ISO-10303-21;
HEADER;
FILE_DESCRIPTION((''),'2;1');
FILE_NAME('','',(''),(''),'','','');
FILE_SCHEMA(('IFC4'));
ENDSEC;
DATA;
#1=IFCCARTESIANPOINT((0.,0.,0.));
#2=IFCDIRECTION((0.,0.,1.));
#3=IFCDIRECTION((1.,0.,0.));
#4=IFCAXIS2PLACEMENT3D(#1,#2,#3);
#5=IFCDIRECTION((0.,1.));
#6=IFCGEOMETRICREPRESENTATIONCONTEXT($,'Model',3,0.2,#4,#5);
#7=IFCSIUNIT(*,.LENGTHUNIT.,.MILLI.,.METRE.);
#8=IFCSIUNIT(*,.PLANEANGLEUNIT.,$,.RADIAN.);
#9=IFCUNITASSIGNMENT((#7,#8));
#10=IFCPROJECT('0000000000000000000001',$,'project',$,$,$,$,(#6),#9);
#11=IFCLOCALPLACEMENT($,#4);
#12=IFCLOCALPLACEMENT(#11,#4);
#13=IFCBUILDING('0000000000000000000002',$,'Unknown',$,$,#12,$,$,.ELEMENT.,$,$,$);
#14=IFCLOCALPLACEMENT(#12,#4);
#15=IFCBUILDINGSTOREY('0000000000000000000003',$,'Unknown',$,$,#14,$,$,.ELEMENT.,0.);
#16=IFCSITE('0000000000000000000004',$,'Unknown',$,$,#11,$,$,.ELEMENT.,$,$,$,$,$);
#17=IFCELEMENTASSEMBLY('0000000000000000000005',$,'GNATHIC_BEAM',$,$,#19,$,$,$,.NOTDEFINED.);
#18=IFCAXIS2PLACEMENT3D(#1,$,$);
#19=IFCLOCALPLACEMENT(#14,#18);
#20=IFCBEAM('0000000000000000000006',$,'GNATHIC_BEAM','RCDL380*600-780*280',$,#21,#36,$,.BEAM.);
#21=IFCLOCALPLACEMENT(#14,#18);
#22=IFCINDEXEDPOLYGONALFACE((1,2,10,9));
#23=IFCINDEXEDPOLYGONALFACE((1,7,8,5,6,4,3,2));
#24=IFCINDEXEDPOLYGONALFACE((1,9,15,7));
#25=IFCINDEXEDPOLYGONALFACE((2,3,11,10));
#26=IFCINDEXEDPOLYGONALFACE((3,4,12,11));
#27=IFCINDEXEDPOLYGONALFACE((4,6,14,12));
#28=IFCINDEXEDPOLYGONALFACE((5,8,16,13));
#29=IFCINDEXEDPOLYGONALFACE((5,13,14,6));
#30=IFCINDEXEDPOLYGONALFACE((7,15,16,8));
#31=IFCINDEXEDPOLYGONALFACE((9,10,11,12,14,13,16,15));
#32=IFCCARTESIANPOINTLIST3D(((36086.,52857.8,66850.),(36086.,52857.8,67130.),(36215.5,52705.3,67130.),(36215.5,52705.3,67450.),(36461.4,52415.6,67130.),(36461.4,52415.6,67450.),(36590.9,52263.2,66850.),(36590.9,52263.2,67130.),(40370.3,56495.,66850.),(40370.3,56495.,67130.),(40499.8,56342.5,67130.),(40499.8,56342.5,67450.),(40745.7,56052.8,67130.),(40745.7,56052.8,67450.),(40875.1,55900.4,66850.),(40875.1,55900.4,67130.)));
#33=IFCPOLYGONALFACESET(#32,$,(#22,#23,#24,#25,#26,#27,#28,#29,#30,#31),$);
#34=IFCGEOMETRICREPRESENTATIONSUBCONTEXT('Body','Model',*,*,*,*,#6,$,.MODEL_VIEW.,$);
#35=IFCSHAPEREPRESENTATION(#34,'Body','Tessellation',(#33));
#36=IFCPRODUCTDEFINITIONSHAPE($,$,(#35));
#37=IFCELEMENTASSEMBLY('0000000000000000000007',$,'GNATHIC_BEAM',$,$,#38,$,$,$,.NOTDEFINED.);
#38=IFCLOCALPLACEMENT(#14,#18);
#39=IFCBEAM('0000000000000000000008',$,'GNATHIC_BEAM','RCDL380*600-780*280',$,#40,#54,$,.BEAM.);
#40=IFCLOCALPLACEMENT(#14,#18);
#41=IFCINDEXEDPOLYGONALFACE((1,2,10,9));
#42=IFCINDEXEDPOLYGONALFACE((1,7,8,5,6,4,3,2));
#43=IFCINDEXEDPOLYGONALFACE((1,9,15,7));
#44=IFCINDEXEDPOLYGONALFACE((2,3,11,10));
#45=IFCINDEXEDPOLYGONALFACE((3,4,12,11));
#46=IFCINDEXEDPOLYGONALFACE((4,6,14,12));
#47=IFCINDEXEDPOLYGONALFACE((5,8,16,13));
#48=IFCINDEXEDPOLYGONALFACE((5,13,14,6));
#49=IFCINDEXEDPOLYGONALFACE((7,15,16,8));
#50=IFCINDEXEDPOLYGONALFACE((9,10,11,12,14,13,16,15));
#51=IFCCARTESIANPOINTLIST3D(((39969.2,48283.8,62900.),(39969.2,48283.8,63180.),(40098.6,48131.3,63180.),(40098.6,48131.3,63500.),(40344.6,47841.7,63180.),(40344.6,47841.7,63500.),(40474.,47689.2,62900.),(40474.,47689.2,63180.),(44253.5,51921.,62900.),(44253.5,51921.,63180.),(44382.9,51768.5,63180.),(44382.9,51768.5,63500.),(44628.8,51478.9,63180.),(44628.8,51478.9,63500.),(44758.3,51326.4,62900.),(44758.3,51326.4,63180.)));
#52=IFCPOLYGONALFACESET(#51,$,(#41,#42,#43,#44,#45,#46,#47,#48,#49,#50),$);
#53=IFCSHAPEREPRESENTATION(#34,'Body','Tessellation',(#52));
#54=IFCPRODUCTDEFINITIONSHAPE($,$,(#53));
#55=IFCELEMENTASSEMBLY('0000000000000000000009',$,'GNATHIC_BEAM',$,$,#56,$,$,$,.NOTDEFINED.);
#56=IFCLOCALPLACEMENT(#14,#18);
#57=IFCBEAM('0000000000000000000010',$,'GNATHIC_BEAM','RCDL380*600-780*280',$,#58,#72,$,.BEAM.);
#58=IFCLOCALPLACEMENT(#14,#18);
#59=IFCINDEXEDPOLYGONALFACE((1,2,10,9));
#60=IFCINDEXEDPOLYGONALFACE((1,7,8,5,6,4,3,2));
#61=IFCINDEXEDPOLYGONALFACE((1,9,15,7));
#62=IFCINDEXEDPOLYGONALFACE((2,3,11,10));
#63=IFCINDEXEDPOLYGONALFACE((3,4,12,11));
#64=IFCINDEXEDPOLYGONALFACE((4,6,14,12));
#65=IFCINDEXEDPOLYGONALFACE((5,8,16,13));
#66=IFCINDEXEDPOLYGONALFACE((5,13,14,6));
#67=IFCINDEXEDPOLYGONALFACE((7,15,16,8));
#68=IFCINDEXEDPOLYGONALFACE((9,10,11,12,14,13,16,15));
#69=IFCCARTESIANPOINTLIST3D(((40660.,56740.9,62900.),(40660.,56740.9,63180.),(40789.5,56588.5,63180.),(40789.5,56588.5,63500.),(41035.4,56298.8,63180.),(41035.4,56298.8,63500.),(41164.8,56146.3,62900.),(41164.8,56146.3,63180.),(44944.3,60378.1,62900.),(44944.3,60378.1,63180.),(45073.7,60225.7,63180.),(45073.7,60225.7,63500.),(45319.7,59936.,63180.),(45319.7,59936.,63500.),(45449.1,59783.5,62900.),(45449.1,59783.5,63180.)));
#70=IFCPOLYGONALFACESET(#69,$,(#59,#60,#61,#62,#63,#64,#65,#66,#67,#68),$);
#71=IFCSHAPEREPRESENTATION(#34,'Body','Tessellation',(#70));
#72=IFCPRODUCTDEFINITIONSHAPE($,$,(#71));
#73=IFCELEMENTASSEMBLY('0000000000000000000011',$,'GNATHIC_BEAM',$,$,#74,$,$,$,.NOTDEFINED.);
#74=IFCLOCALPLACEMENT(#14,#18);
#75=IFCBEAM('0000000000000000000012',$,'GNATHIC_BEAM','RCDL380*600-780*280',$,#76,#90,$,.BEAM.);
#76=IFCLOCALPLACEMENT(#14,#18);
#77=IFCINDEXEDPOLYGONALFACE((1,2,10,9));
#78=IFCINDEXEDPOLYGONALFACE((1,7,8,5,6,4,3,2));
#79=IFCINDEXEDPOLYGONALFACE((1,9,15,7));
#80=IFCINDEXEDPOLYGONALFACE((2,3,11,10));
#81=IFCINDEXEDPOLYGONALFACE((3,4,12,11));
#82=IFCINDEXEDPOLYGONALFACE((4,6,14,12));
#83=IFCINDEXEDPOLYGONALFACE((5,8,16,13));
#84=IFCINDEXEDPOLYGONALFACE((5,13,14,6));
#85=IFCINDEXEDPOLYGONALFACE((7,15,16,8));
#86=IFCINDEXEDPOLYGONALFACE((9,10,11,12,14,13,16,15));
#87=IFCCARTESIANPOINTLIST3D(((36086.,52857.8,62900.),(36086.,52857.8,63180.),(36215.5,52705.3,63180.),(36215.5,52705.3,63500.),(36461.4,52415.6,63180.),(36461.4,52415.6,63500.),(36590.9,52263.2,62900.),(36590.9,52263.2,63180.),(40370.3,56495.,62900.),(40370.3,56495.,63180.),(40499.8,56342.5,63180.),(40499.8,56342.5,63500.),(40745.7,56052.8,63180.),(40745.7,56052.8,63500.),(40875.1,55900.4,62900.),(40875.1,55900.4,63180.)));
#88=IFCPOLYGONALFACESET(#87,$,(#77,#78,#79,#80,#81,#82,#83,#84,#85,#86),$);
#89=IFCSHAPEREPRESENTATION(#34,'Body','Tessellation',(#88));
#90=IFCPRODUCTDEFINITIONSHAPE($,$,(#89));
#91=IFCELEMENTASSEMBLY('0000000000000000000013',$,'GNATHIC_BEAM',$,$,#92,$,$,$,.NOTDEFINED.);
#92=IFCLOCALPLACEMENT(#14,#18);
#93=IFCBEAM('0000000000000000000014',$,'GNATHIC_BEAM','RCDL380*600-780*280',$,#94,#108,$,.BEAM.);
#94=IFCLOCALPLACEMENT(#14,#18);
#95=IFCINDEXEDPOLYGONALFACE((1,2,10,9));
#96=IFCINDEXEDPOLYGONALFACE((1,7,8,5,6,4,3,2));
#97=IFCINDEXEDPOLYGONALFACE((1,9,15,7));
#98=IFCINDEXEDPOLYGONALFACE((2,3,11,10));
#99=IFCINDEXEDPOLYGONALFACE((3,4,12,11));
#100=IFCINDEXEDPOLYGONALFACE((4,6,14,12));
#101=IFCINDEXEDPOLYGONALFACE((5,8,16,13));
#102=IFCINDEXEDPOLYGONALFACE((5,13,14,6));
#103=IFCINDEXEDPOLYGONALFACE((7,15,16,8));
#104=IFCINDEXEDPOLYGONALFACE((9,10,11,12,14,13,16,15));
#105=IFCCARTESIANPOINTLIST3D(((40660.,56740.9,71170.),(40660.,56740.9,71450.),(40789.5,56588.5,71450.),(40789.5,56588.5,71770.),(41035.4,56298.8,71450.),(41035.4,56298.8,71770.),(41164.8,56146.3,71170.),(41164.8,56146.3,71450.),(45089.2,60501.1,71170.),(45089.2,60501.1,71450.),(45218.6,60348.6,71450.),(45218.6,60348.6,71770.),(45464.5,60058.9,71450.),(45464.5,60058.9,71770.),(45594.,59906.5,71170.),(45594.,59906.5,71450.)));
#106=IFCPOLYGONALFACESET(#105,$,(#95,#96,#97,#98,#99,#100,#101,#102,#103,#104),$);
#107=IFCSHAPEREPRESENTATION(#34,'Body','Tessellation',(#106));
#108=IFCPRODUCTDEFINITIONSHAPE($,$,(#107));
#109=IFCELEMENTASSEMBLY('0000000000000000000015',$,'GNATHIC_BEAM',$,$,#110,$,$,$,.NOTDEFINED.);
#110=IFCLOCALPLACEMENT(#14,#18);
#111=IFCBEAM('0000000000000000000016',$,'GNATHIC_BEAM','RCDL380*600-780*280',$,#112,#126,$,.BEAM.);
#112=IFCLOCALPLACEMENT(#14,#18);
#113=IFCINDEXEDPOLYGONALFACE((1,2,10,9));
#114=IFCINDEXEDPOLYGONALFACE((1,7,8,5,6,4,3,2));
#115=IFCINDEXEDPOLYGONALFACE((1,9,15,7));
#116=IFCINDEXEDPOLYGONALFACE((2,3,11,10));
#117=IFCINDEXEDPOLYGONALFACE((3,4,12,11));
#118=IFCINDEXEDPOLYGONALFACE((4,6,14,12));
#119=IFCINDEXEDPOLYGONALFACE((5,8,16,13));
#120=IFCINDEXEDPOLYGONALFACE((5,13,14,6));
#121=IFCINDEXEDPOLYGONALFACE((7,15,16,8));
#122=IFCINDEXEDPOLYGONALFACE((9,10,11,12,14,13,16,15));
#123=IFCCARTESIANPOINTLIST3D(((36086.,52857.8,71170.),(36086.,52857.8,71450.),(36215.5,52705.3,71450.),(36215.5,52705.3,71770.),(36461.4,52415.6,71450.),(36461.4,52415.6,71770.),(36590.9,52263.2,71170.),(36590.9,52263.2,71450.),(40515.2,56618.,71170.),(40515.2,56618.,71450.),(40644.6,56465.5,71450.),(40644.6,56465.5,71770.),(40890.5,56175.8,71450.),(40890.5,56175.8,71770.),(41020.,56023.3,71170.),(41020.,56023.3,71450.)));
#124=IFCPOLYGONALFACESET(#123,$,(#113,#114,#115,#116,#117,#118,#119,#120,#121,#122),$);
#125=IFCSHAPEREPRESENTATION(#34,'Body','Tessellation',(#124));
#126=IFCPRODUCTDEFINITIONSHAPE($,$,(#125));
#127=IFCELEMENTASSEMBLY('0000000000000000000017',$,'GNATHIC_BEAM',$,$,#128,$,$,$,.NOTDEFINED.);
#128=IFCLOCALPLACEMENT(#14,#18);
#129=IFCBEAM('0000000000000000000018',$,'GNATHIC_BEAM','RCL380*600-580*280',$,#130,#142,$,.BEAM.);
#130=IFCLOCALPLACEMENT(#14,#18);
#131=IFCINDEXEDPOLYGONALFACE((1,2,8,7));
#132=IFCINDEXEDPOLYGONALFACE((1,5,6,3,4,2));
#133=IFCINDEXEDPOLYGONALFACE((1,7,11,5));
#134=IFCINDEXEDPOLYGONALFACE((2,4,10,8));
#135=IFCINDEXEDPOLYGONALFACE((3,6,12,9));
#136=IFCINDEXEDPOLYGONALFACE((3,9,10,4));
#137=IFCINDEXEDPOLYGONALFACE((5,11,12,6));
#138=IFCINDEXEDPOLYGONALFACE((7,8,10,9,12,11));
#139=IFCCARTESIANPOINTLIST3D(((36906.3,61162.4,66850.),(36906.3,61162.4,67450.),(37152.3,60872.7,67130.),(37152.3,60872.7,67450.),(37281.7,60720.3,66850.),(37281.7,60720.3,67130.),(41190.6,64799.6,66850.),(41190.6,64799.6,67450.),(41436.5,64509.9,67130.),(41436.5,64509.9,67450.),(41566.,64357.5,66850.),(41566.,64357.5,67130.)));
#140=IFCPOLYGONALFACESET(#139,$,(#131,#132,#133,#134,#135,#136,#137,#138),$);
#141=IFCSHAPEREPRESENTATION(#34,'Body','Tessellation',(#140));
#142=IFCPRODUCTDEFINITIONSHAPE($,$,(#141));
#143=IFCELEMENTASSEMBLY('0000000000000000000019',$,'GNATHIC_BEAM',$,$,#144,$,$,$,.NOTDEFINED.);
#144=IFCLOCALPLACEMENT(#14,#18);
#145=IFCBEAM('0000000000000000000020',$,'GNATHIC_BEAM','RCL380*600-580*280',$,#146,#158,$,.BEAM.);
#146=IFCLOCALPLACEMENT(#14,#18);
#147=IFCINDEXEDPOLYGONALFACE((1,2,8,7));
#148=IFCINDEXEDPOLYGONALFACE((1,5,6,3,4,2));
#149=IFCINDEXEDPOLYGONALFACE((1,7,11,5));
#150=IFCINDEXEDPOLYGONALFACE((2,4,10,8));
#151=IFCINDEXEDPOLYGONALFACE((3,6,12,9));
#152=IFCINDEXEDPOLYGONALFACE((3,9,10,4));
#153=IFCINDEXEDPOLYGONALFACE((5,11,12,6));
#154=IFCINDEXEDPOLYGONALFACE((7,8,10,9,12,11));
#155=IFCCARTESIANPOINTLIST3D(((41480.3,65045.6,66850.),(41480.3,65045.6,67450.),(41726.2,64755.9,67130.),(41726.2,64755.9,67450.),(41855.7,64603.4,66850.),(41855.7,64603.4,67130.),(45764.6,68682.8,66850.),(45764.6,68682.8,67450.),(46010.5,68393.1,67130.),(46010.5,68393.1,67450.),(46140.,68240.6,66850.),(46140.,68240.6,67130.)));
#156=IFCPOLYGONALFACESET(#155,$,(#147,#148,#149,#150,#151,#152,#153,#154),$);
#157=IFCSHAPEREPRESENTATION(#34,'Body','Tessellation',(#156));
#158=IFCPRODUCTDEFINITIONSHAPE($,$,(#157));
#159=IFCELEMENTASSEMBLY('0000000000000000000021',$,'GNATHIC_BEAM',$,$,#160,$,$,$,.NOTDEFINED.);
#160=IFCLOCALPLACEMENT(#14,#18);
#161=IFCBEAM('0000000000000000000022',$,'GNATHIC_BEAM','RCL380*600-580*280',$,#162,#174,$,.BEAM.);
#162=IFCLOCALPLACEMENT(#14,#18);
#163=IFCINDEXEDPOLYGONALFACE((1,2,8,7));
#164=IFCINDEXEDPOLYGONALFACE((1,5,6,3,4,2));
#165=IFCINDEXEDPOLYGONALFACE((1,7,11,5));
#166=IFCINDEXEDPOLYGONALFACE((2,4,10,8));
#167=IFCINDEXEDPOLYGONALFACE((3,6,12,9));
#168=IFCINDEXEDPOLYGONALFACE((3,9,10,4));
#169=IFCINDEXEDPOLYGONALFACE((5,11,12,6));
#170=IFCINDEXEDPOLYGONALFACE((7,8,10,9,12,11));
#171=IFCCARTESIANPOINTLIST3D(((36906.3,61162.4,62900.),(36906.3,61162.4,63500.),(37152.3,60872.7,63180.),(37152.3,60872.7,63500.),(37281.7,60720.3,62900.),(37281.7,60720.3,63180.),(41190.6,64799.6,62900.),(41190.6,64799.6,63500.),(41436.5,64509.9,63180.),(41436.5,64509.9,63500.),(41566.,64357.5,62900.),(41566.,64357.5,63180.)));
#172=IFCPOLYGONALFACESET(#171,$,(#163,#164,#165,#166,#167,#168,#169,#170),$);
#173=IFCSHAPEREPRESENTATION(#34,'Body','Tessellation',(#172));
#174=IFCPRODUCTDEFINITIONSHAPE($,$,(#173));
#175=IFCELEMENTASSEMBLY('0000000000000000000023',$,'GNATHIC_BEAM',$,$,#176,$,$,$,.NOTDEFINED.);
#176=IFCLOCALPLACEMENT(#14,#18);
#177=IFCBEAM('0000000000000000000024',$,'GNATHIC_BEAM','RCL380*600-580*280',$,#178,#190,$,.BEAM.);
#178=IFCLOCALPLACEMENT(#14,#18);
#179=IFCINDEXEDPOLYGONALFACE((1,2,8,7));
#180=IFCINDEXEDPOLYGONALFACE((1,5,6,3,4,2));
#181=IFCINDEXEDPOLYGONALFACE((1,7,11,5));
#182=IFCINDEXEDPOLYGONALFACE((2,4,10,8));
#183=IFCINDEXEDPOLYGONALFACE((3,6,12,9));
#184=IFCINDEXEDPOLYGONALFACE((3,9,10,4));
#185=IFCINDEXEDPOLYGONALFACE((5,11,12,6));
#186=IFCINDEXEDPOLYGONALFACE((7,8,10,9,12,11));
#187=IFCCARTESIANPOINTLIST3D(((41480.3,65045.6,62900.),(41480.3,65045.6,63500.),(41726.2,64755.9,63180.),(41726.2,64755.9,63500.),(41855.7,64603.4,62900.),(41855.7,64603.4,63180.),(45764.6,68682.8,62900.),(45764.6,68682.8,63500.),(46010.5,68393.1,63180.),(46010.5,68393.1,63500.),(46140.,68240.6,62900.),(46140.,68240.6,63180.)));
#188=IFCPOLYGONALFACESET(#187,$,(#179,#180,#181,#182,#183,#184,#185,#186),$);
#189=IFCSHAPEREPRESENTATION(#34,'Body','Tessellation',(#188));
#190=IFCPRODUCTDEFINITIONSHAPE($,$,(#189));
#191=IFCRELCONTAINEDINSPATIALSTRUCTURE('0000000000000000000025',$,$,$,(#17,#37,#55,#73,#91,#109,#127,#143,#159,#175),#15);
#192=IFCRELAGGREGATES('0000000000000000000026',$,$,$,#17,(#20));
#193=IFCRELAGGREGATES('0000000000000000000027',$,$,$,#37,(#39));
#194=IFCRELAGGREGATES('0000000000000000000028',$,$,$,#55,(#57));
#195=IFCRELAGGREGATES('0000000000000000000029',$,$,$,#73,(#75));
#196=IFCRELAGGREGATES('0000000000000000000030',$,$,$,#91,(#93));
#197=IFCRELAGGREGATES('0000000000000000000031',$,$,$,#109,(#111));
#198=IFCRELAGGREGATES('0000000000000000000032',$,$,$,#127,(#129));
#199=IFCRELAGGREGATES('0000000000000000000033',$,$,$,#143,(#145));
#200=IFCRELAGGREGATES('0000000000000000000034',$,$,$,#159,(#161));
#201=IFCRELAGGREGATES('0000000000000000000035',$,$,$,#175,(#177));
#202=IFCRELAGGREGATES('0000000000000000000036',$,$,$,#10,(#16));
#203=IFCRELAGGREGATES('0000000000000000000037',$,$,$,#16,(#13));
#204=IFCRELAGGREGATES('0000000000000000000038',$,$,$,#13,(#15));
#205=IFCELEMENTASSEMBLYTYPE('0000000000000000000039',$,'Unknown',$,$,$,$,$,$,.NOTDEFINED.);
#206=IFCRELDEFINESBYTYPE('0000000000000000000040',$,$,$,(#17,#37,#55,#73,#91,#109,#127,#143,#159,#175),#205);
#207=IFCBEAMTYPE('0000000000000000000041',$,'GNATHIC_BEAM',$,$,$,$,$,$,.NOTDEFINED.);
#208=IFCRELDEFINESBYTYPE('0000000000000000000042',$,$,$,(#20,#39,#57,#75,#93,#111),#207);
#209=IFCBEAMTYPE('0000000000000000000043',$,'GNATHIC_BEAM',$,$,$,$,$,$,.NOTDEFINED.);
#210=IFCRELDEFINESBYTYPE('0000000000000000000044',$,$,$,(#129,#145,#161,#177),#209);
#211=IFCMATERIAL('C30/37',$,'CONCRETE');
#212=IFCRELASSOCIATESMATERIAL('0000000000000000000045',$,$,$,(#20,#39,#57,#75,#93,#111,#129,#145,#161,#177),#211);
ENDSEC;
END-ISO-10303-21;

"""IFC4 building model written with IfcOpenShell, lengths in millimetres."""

from ifc_helpers import new_model, si_unit, direction, frame, origin_with_axes, place, context, subcontext, project, spatial, polyline, outline, extrude, material, material_profile, profile_set, profile_usage, type_object, element, aggregate, save


model = new_model("IFC4")

# Units and contexts
model_context = context("Model", 3, precision=0.2, world=origin_with_axes(), true_north=direction((0.0, 1.0)))
body_context = subcontext(model_context, "Body", "Model", "MODEL_VIEW")
ifc_project = project(units=[si_unit("LENGTHUNIT", "METRE", prefix="MILLI"), si_unit("PLANEANGLEUNIT", "RADIAN")], contexts=[model_context])

# Site, building, storey
site_placement = place(None, origin_with_axes())
site = spatial("IfcSite", under=ifc_project, at=site_placement, Name="Unknown", CompositionType="ELEMENT")
building_placement = place(site_placement, origin_with_axes())
building = spatial("IfcBuilding", under=site, at=building_placement, Name="Unknown", CompositionType="ELEMENT")
storey_placement = place(building_placement, origin_with_axes())
storey = spatial("IfcBuildingStorey", under=building, at=storey_placement, Name="Unknown", CompositionType="ELEMENT", Elevation=0.0)

# Shared definitions
element_assembly_type = type_object("IfcElementAssemblyType", Name="Unknown", PredefinedType="NOTDEFINED")

# Element assemblies, beams
ifc_material_1 = material(Name="C30/37", Category="CONCRETE")
ifc_material_profile_1 = material_profile(ifc_material_1, outline(polyline([(-390.0, -300.0), (390.0, -300.0), (390.0, -20.0), (190.0, -20.0), (190.0, 300.0), (-190.0, 300.0), (-190.0, -20.0), (-390.0, -20.0), (-390.0, -300.0)])), Name="RCDL380*600-780*280")
ifc_profile_set_1 = profile_set([ifc_material_profile_1])
ifc_profile_usage_1 = profile_usage(ifc_profile_set_1, cardinal=2)
beam_type_1 = type_object("IfcBeamType", Name="GNATHIC_BEAM")
assembly_1_placement = place(storey_placement, frame((36338.5, 52560.5, 67150.0), z_axis=(0.64719, -0.762329, 0.0), x_axis=(0.762329, 0.64719, 0.0)))
assembly_1 = element("IfcElementAssembly", 1, at=assembly_1_placement, inside=storey, type_object=element_assembly_type, Name="GNATHIC_BEAM", PredefinedType="NOTDEFINED")
beam_1_placement = place(assembly_1_placement, origin_with_axes())
beam_1 = element("IfcBeam", 2, at=beam_1_placement, type_object=beam_type_1, material=ifc_profile_usage_1, Name="GNATHIC_BEAM", Description="RCDL380*600-780*280", PredefinedType="BEAM", context=body_context, shape_type="SolidModel", body=[
    extrude(outline(polyline([(-390.0, -300.0), (390.0, -300.0), (390.0, -20.0), (190.0, -20.0), (190.0, 300.0), (-190.0, 300.0), (-190.0, -20.0), (-390.0, -20.0), (-390.0, -300.0)])), frame((0.0, 0.0, 0.0), z_axis=(-1.0, 0.0, 0.0), x_axis=(0.0, 0.0, 1.0)), (0.0, 0.0, -1.0), 5620.0),
])
aggregate(assembly_1, [beam_1])
assembly_2_placement = place(storey_placement, frame((40221.6, 47986.5, 63200.0), z_axis=(0.64719, -0.762329, 0.0), x_axis=(0.762329, 0.64719, 0.0)))
assembly_2 = element("IfcElementAssembly", 3, at=assembly_2_placement, inside=storey, type_object=element_assembly_type, Name="GNATHIC_BEAM", PredefinedType="NOTDEFINED")
beam_2_placement = place(assembly_2_placement, origin_with_axes())
beam_2 = element("IfcBeam", 4, at=beam_2_placement, type_object=beam_type_1, material=ifc_profile_usage_1, Name="GNATHIC_BEAM", Description="RCDL380*600-780*280", PredefinedType="BEAM", context=body_context, shape_type="SolidModel", body=[
    extrude(outline(polyline([(-390.0, -300.0), (390.0, -300.0), (390.0, -20.0), (190.0, -20.0), (190.0, 300.0), (-190.0, 300.0), (-190.0, -20.0), (-390.0, -20.0), (-390.0, -300.0)])), frame((0.0, 0.0, 0.0), z_axis=(-1.0, 0.0, 0.0), x_axis=(0.0, 0.0, 1.0)), (0.0, 0.0, -1.0), 5620.0),
])
aggregate(assembly_2, [beam_2])
assembly_3_placement = place(storey_placement, frame((40912.4, 56443.6, 63200.0), z_axis=(0.64719, -0.762329, 0.0), x_axis=(0.762329, 0.64719, 0.0)))
assembly_3 = element("IfcElementAssembly", 5, at=assembly_3_placement, inside=storey, type_object=element_assembly_type, Name="GNATHIC_BEAM", PredefinedType="NOTDEFINED")
beam_3_placement = place(assembly_3_placement, origin_with_axes())
beam_3 = element("IfcBeam", 6, at=beam_3_placement, type_object=beam_type_1, material=ifc_profile_usage_1, Name="GNATHIC_BEAM", Description="RCDL380*600-780*280", PredefinedType="BEAM", context=body_context, shape_type="SolidModel", body=[
    extrude(outline(polyline([(-390.0, -300.0), (390.0, -300.0), (390.0, -20.0), (190.0, -20.0), (190.0, 300.0), (-190.0, 300.0), (-190.0, -20.0), (-390.0, -20.0), (-390.0, -300.0)])), frame((0.0, 0.0, 0.0), z_axis=(-1.0, 0.0, 0.0), x_axis=(0.0, 0.0, 1.0)), (0.0, 0.0, -1.0), 5620.0),
])
aggregate(assembly_3, [beam_3])
assembly_4_placement = place(storey_placement, frame((36338.5, 52560.5, 63200.0), z_axis=(0.64719, -0.762329, 0.0), x_axis=(0.762329, 0.64719, 0.0)))
assembly_4 = element("IfcElementAssembly", 7, at=assembly_4_placement, inside=storey, type_object=element_assembly_type, Name="GNATHIC_BEAM", PredefinedType="NOTDEFINED")
beam_4_placement = place(assembly_4_placement, origin_with_axes())
beam_4 = element("IfcBeam", 8, at=beam_4_placement, type_object=beam_type_1, material=ifc_profile_usage_1, Name="GNATHIC_BEAM", Description="RCDL380*600-780*280", PredefinedType="BEAM", context=body_context, shape_type="SolidModel", body=[
    extrude(outline(polyline([(-390.0, -300.0), (390.0, -300.0), (390.0, -20.0), (190.0, -20.0), (190.0, 300.0), (-190.0, 300.0), (-190.0, -20.0), (-390.0, -20.0), (-390.0, -300.0)])), frame((0.0, 0.0, 0.0), z_axis=(-1.0, 0.0, 0.0), x_axis=(0.0, 0.0, 1.0)), (0.0, 0.0, -1.0), 5620.0),
])
aggregate(assembly_4, [beam_4])
assembly_5_placement = place(storey_placement, frame((40912.4, 56443.6, 71470.0), z_axis=(0.64719, -0.762329, 0.0), x_axis=(0.762329, 0.64719, 0.0)))
assembly_5 = element("IfcElementAssembly", 9, at=assembly_5_placement, inside=storey, type_object=element_assembly_type, Name="GNATHIC_BEAM", PredefinedType="NOTDEFINED")
beam_5_placement = place(assembly_5_placement, origin_with_axes())
beam_5 = element("IfcBeam", 10, at=beam_5_placement, type_object=beam_type_1, material=ifc_profile_usage_1, Name="GNATHIC_BEAM", Description="RCDL380*600-780*280", PredefinedType="BEAM", context=body_context, shape_type="SolidModel", body=[
    extrude(outline(polyline([(-390.0, -300.0), (390.0, -300.0), (390.0, -20.0), (190.0, -20.0), (190.0, 300.0), (-190.0, 300.0), (-190.0, -20.0), (-390.0, -20.0), (-390.0, -300.0)])), frame((0.0, 0.0, 0.0), z_axis=(-1.0, 0.0, 0.0), x_axis=(0.0, 0.0, 1.0)), (0.0, 0.0, -1.0), 5810.0),
])
aggregate(assembly_5, [beam_5])
assembly_6_placement = place(storey_placement, frame((36338.5, 52560.5, 71470.0), z_axis=(0.64719, -0.762329, 0.0), x_axis=(0.762329, 0.64719, 0.0)))
assembly_6 = element("IfcElementAssembly", 11, at=assembly_6_placement, inside=storey, type_object=element_assembly_type, Name="GNATHIC_BEAM", PredefinedType="NOTDEFINED")
beam_6_placement = place(assembly_6_placement, origin_with_axes())
beam_6 = element("IfcBeam", 12, at=beam_6_placement, type_object=beam_type_1, material=ifc_profile_usage_1, Name="GNATHIC_BEAM", Description="RCDL380*600-780*280", PredefinedType="BEAM", context=body_context, shape_type="SolidModel", body=[
    extrude(outline(polyline([(-390.0, -300.0), (390.0, -300.0), (390.0, -20.0), (190.0, -20.0), (190.0, 300.0), (-190.0, 300.0), (-190.0, -20.0), (-390.0, -20.0), (-390.0, -300.0)])), frame((0.0, 0.0, 0.0), z_axis=(-1.0, 0.0, 0.0), x_axis=(0.0, 0.0, 1.0)), (0.0, 0.0, -1.0), 5810.0),
])
aggregate(assembly_6, [beam_6])
assembly_7_placement = place(storey_placement, frame((37029.3, 61017.6, 67150.0), z_axis=(0.64719, -0.762329, 0.0), x_axis=(0.762329, 0.64719, 0.0)))
assembly_7 = element("IfcElementAssembly", 13, at=assembly_7_placement, inside=storey, type_object=element_assembly_type, Name="GNATHIC_BEAM", PredefinedType="NOTDEFINED")
ifc_material_profile_2 = material_profile(ifc_material_1, outline(polyline([(-190.0, -300.0), (390.0, -300.0), (390.0, -20.0), (190.0, -20.0), (190.0, 300.0), (-190.0, 300.0), (-190.0, -300.0)])), Name="RCL380*600-580*280")
ifc_profile_set_2 = profile_set([ifc_material_profile_2])
ifc_profile_usage_2 = profile_usage(ifc_profile_set_2, cardinal=2)
beam_type_2 = type_object("IfcBeamType", Name="GNATHIC_BEAM")
beam_7_placement = place(assembly_7_placement, origin_with_axes())
beam_7 = element("IfcBeam", 14, at=beam_7_placement, type_object=beam_type_2, material=ifc_profile_usage_2, Name="GNATHIC_BEAM", Description="RCL380*600-580*280", PredefinedType="BEAM", context=body_context, shape_type="SolidModel", body=[
    extrude(outline(polyline([(-190.0, -300.0), (390.0, -300.0), (390.0, -20.0), (190.0, -20.0), (190.0, 300.0), (-190.0, 300.0), (-190.0, -300.0)])), frame((0.0, 0.0, 0.0), z_axis=(-1.0, 0.0, 0.0), x_axis=(0.0, 0.0, 1.0)), (0.0, 0.0, -1.0), 5620.0),
])
aggregate(assembly_7, [beam_7])
assembly_8_placement = place(storey_placement, frame((41603.3, 64900.7, 67150.0), z_axis=(0.64719, -0.762329, 0.0), x_axis=(0.762329, 0.64719, 0.0)))
assembly_8 = element("IfcElementAssembly", 15, at=assembly_8_placement, inside=storey, type_object=element_assembly_type, Name="GNATHIC_BEAM", PredefinedType="NOTDEFINED")
beam_8_placement = place(assembly_8_placement, origin_with_axes())
beam_8 = element("IfcBeam", 16, at=beam_8_placement, type_object=beam_type_2, material=ifc_profile_usage_2, Name="GNATHIC_BEAM", Description="RCL380*600-580*280", PredefinedType="BEAM", context=body_context, shape_type="SolidModel", body=[
    extrude(outline(polyline([(-190.0, -300.0), (390.0, -300.0), (390.0, -20.0), (190.0, -20.0), (190.0, 300.0), (-190.0, 300.0), (-190.0, -300.0)])), frame((0.0, 0.0, 0.0), z_axis=(-1.0, 0.0, 0.0), x_axis=(0.0, 0.0, 1.0)), (0.0, 0.0, -1.0), 5620.0),
])
aggregate(assembly_8, [beam_8])
assembly_9_placement = place(storey_placement, frame((37029.3, 61017.6, 63200.0), z_axis=(0.64719, -0.762329, 0.0), x_axis=(0.762329, 0.64719, 0.0)))
assembly_9 = element("IfcElementAssembly", 17, at=assembly_9_placement, inside=storey, type_object=element_assembly_type, Name="GNATHIC_BEAM", PredefinedType="NOTDEFINED")
beam_9_placement = place(assembly_9_placement, origin_with_axes())
beam_9 = element("IfcBeam", 18, at=beam_9_placement, type_object=beam_type_2, material=ifc_profile_usage_2, Name="GNATHIC_BEAM", Description="RCL380*600-580*280", PredefinedType="BEAM", context=body_context, shape_type="SolidModel", body=[
    extrude(outline(polyline([(-190.0, -300.0), (390.0, -300.0), (390.0, -20.0), (190.0, -20.0), (190.0, 300.0), (-190.0, 300.0), (-190.0, -300.0)])), frame((0.0, 0.0, 0.0), z_axis=(-1.0, 0.0, 0.0), x_axis=(0.0, 0.0, 1.0)), (0.0, 0.0, -1.0), 5620.0),
])
aggregate(assembly_9, [beam_9])
assembly_10_placement = place(storey_placement, frame((41603.3, 64900.7, 63200.0), z_axis=(0.64719, -0.762329, 0.0), x_axis=(0.762329, 0.64719, 0.0)))
assembly_10 = element("IfcElementAssembly", 19, at=assembly_10_placement, inside=storey, type_object=element_assembly_type, Name="GNATHIC_BEAM", PredefinedType="NOTDEFINED")
beam_10_placement = place(assembly_10_placement, origin_with_axes())
beam_10 = element("IfcBeam", 20, at=beam_10_placement, type_object=beam_type_2, material=ifc_profile_usage_2, Name="GNATHIC_BEAM", Description="RCL380*600-580*280", PredefinedType="BEAM", context=body_context, shape_type="SolidModel", body=[
    extrude(outline(polyline([(-190.0, -300.0), (390.0, -300.0), (390.0, -20.0), (190.0, -20.0), (190.0, 300.0), (-190.0, 300.0), (-190.0, -300.0)])), frame((0.0, 0.0, 0.0), z_axis=(-1.0, 0.0, 0.0), x_axis=(0.0, 0.0, 1.0)), (0.0, 0.0, -1.0), 5620.0),
])
aggregate(assembly_10, [beam_10])

save(model, "model.ifc")
